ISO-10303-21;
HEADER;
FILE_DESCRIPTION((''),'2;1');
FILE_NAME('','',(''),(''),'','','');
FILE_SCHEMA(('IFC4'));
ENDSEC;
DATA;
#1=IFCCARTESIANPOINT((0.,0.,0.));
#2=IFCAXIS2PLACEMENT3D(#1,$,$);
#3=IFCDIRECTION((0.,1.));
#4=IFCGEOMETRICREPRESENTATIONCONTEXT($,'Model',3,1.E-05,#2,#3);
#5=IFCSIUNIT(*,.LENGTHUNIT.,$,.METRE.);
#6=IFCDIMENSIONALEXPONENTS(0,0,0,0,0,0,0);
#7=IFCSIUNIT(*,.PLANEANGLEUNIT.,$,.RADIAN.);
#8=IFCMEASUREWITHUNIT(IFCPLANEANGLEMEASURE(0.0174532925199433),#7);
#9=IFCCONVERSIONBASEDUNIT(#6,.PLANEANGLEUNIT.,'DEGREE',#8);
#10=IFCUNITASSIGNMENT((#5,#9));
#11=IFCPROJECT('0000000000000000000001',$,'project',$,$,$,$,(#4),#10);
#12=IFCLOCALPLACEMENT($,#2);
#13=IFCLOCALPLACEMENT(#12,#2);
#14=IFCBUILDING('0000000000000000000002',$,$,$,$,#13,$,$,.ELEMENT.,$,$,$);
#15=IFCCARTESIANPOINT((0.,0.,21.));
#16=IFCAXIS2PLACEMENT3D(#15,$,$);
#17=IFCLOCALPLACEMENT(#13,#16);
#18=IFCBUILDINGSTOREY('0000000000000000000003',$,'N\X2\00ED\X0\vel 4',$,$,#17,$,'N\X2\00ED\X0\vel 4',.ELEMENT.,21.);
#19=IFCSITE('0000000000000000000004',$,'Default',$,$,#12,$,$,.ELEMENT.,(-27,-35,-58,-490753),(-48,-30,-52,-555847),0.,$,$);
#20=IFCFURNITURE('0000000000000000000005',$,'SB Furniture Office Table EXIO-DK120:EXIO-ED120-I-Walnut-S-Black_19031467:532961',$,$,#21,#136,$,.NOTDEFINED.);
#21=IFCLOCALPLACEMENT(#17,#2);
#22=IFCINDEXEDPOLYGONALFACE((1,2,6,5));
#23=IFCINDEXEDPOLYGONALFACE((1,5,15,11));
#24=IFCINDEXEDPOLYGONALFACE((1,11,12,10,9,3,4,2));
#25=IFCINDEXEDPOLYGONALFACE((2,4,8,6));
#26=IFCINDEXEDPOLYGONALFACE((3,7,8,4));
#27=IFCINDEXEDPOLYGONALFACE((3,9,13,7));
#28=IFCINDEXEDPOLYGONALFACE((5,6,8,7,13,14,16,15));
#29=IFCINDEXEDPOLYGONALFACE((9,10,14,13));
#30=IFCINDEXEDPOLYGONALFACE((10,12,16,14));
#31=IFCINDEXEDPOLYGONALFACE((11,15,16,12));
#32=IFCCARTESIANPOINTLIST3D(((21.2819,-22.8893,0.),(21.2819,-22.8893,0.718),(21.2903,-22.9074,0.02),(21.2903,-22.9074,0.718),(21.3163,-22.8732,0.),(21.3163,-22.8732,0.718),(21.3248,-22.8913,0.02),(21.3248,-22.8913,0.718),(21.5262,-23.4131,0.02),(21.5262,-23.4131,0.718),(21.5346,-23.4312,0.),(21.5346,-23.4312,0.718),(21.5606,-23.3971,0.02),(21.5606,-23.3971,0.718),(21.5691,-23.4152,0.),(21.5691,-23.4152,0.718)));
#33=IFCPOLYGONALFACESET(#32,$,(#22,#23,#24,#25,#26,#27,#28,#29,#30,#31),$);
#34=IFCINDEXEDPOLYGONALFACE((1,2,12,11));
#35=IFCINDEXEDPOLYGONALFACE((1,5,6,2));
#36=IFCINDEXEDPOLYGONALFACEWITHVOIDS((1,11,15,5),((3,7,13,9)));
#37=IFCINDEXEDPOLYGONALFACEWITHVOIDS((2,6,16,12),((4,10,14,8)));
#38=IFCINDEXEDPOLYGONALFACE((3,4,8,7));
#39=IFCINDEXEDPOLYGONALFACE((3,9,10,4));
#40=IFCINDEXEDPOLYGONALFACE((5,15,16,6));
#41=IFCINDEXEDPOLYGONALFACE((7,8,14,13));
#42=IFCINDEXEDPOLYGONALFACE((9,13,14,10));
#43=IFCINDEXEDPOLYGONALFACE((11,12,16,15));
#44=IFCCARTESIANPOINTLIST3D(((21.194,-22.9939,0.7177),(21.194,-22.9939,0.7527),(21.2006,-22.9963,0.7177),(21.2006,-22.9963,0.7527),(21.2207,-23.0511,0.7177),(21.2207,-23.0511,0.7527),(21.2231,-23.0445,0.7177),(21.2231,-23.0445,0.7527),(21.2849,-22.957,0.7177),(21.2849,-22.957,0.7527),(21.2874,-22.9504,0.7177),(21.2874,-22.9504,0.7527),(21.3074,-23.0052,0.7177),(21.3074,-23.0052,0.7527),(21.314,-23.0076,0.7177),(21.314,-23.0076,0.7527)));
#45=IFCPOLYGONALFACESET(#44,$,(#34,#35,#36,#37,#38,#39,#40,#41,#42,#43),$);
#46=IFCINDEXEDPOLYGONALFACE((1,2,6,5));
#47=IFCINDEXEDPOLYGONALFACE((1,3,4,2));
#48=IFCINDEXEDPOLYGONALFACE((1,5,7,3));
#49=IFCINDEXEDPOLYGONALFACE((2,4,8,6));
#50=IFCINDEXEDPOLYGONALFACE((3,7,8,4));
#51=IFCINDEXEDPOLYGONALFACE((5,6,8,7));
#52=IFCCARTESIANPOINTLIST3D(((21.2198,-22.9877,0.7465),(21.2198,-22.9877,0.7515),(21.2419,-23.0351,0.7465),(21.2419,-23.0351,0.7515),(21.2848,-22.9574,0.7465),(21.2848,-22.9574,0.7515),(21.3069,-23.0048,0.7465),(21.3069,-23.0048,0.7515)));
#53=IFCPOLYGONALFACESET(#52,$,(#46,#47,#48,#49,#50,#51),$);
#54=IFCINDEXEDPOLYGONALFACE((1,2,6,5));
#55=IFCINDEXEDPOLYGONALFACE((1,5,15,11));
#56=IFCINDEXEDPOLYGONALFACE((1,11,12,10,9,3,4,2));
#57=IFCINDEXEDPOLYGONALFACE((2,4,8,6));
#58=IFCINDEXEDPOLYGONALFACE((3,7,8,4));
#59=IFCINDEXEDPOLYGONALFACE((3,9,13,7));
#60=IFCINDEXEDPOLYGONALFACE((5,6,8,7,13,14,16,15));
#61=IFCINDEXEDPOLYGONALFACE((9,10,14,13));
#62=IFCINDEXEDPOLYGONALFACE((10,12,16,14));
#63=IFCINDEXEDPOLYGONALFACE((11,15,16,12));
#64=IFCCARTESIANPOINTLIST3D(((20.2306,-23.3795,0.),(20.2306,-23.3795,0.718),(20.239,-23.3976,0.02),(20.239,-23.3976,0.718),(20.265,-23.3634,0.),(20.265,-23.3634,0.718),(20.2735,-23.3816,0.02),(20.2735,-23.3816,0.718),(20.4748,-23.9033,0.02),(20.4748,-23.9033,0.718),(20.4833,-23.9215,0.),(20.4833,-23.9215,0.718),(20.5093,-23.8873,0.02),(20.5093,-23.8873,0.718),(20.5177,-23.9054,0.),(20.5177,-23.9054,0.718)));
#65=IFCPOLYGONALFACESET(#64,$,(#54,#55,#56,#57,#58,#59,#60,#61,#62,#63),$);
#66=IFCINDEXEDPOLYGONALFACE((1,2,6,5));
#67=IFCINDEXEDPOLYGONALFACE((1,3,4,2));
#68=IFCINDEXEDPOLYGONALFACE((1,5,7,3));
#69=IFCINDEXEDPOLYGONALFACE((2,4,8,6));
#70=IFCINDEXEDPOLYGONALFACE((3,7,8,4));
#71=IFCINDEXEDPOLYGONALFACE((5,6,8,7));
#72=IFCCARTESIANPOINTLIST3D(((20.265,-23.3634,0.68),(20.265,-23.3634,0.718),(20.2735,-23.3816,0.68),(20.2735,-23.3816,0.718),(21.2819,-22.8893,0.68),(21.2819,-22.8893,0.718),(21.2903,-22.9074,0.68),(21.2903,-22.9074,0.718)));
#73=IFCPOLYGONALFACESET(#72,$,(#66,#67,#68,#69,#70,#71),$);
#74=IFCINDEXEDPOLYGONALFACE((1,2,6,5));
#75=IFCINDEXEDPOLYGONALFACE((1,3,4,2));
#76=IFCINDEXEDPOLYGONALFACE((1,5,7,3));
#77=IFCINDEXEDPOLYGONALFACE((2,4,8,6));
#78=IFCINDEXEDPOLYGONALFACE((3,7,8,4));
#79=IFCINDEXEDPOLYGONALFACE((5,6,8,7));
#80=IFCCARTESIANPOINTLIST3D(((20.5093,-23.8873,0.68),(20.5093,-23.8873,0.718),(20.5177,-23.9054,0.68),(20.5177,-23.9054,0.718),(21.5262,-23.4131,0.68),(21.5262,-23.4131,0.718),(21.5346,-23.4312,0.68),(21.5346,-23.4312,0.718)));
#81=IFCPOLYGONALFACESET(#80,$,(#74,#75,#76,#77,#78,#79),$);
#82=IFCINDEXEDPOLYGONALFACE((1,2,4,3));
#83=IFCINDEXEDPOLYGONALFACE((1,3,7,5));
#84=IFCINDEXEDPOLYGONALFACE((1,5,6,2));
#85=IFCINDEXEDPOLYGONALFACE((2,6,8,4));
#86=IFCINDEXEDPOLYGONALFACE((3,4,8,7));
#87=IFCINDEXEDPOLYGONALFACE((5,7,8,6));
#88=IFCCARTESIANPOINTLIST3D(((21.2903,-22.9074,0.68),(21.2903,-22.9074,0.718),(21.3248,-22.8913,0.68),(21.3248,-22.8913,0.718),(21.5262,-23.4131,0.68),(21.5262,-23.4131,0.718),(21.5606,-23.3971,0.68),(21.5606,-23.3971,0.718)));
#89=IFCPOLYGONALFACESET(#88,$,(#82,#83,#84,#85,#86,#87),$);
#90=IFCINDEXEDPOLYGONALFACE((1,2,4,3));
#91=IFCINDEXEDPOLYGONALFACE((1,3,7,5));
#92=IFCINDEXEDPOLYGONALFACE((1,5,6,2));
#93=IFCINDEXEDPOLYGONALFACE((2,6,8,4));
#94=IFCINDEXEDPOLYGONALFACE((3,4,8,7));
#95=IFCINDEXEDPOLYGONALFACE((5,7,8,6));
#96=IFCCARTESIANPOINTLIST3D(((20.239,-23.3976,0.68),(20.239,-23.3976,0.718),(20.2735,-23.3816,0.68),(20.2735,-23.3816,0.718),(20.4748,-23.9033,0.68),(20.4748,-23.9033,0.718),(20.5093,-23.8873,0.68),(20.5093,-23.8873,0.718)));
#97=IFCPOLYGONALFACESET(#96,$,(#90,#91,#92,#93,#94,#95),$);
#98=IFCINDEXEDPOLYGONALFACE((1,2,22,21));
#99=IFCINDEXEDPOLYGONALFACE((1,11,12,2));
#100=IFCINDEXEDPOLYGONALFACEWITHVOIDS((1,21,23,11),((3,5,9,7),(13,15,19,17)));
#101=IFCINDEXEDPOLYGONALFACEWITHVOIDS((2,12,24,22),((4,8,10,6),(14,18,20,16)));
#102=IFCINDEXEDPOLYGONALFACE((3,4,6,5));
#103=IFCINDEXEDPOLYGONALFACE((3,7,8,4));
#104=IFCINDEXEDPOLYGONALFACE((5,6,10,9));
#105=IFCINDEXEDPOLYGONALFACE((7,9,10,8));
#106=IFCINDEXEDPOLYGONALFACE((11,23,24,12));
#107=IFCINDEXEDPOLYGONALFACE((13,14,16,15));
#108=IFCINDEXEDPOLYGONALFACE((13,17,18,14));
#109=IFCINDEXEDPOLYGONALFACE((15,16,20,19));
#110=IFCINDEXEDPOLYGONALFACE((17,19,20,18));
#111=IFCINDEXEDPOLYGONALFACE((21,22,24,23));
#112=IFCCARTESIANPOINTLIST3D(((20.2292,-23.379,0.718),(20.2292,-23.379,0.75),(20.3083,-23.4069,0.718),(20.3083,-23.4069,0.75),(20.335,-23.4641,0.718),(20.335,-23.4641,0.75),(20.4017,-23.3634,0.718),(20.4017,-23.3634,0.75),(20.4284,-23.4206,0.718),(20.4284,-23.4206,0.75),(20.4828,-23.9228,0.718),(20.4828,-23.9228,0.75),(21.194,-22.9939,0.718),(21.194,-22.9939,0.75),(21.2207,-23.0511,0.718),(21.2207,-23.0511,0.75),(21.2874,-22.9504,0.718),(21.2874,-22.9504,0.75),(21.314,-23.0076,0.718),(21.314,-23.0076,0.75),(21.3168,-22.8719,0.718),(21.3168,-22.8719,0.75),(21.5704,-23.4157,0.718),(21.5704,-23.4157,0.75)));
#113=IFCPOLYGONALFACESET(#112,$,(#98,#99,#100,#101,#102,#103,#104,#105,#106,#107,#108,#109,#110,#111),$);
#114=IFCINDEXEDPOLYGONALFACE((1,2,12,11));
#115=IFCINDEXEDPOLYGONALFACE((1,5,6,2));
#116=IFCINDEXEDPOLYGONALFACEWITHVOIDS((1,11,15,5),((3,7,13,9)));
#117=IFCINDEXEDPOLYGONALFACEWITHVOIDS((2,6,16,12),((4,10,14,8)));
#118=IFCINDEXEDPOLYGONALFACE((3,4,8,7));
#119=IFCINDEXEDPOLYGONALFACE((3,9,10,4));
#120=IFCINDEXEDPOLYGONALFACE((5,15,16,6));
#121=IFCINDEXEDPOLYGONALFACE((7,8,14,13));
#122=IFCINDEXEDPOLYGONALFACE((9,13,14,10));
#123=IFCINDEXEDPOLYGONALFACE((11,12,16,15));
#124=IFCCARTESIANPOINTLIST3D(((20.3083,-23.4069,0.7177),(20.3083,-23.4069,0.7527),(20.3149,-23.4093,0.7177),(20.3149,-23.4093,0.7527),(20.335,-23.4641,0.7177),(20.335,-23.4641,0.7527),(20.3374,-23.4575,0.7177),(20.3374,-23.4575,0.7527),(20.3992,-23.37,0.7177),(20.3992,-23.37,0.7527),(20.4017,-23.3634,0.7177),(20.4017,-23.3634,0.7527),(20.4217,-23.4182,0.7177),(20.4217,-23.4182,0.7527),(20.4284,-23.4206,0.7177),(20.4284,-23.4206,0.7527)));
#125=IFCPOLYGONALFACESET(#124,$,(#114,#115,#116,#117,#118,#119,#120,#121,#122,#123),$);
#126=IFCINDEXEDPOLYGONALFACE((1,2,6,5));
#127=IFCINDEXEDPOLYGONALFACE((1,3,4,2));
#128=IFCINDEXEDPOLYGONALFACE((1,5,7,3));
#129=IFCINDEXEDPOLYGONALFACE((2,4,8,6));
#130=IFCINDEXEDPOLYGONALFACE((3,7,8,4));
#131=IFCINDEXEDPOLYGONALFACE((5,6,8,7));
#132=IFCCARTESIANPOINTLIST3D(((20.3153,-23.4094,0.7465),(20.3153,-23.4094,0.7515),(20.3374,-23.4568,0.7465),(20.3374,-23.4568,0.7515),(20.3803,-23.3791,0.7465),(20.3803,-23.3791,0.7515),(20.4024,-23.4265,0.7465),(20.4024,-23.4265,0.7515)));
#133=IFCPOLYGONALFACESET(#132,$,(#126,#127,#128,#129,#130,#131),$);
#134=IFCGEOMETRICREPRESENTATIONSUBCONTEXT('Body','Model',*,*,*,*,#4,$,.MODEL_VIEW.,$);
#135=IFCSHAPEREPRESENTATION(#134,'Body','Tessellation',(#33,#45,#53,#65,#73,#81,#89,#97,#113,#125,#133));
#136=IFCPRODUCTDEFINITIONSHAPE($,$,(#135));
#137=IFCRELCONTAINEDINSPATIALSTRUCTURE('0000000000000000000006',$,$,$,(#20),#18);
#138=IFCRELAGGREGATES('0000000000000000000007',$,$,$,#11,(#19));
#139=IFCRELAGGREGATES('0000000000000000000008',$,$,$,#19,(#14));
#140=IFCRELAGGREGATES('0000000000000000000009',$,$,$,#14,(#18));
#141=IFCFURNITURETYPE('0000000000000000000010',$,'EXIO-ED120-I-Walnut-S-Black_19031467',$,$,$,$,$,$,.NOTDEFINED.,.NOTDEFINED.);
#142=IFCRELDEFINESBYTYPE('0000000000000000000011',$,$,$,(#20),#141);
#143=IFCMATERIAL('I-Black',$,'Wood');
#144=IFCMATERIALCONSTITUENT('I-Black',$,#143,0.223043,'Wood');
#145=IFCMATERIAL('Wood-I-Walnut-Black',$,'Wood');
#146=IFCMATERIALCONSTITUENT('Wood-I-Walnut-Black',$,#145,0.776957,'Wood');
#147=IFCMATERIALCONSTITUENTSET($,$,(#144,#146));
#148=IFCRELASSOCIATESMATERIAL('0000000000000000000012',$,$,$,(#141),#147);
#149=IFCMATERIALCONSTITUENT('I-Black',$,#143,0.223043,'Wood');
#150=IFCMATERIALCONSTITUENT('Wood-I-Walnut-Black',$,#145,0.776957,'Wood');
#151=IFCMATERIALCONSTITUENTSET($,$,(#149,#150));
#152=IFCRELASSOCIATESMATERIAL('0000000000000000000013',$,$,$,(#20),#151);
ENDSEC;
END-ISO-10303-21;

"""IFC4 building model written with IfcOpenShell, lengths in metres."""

from ifc_helpers import new_model, entity, si_unit, converted_unit, direction, frame, frame_2d, origin, origin_2d_with_axis, place, context, subcontext, project, spatial, polyline, rectangle, outline, extrude, source, transform, mapped, material, constituent, constituent_set, type_object, type_shapes, element, save


model = new_model("IFC4")

# Units and contexts
model_context = context("Model", 3, precision=1e-05, world=origin(), true_north=direction((0.0, 1.0)))
body_context = subcontext(model_context, "Body", "Model", "MODEL_VIEW")
ifc_project = project(units=[si_unit("LENGTHUNIT", "METRE"), converted_unit("PLANEANGLEUNIT", "DEGREE", entity("IfcPlaneAngleMeasure", 0.0174532925199433), si_unit("PLANEANGLEUNIT", "RADIAN"), dimensions=[0, 0, 0, 0, 0, 0, 0])], contexts=[model_context])

# Site, building, storey
site_placement = place(None, origin())
site = spatial("IfcSite", under=ifc_project, at=site_placement, Name="Default", CompositionType="ELEMENT", RefLatitude=(-27, -35, -58, -490753), RefLongitude=(-48, -30, -52, -555847), RefElevation=0.0)
building_placement = place(site_placement, origin())
building = spatial("IfcBuilding", under=site, at=building_placement, CompositionType="ELEMENT")
storey_placement = place(building_placement, frame((0.0, 0.0, 21.0)))
storey = spatial("IfcBuildingStorey", under=building, at=storey_placement, Name="Nível 4", LongName="Nível 4", CompositionType="ELEMENT", Elevation=21.0)

# Furniture
ifc_material_1 = material(Name="I-Black", Category="Wood")
ifc_material_2 = material(Name="Wood-I-Walnut-Black", Category="Wood")
ifc_constituent_1 = constituent(ifc_material_1, Name="I-Black", Category="Wood", fraction=0.223043)
ifc_constituent_2 = constituent(ifc_material_2, Name="Wood-I-Walnut-Black", Category="Wood", fraction=0.776957)
ifc_constituent_set_1 = constituent_set(constituents=[ifc_constituent_1, ifc_constituent_2])
furniture_type = type_object("IfcFurnitureType", Name="EXIO-ED120-I-Walnut-S-Black_19031467", AssemblyPlace="NOTDEFINED", PredefinedType="NOTDEFINED", material=ifc_constituent_set_1)
shared_shape_1 = source(origin(), body_context, "Body", "SweptSolid", [
    extrude(outline(polyline([(-0.354, -0.279), (-0.354, -0.299), (0.364, -0.299), (0.364, 0.299), (-0.354, 0.299), (-0.354, 0.279), (0.344, 0.279), (0.344, -0.279), (-0.354, -0.279)])), frame((0.561, 0.0, 0.364), z_axis=(-1.0, 0.0, 0.0), x_axis=(0.0, 0.0, -1.0)), (0.0, 0.0, -1.0), 0.038),
    extrude(outline(polyline([(-0.0316, -0.0515), (0.0316, -0.0515), (0.0316, 0.0515), (-0.0316, 0.0515), (-0.0316, -0.0515)]), holes=[polyline([(0.0266, -0.0465), (-0.0266, -0.0465), (-0.0266, 0.0465), (0.0266, 0.0465), (0.0266, -0.0465)])]), frame((0.4886, 0.2097, 0.7177), z_axis=(0.0, 0.0, 1.0), x_axis=(0.0, -1.0, 0.0)), (0.0, 0.0, 1.0), 0.035),
    extrude(rectangle(XDim=0.0717, YDim=0.0523, at=origin_2d_with_axis()), frame((0.499, 0.2099, 0.7465), z_axis=(0.0, 0.0, 1.0), x_axis=(-1.0, 0.0, 0.0)), (0.0, 0.0, 1.0), 0.005),
    extrude(outline(polyline([(-0.354, -0.279), (-0.354, -0.299), (0.364, -0.299), (0.364, 0.299), (-0.354, 0.299), (-0.354, 0.279), (0.344, 0.279), (0.344, -0.279), (-0.354, -0.279)])), frame((-0.599, 0.0, 0.364), z_axis=(-1.0, 0.0, 0.0), x_axis=(0.0, 0.0, -1.0)), (0.0, 0.0, -1.0), 0.038),
    extrude(rectangle(XDim=1.122, YDim=0.02, at=frame_2d((0.0, 0.0), x_axis=(1.0, 0.0))), frame((0.0, 0.289, 0.68), z_axis=(0.0, 0.0, 1.0), x_axis=(-1.0, 0.0, 0.0)), (0.0, 0.0, 1.0), 0.038),
    extrude(rectangle(XDim=1.122, YDim=0.02, at=origin_2d_with_axis()), frame((0.0, -0.289, 0.68), z_axis=(0.0, 0.0, 1.0), x_axis=(-1.0, 0.0, 0.0)), (0.0, 0.0, 1.0), 0.038),
    extrude(rectangle(XDim=0.038, YDim=0.558, at=frame_2d((0.0, 0.0), x_axis=(1.0, 0.0))), frame((0.58, 0.0, 0.68), z_axis=(0.0, 0.0, 1.0), x_axis=(-1.0, 0.0, 0.0)), (0.0, 0.0, 1.0), 0.038),
    extrude(rectangle(XDim=0.038, YDim=0.558, at=origin_2d_with_axis()), frame((-0.58, 0.0, 0.68), z_axis=(0.0, 0.0, 1.0), x_axis=(-1.0, 0.0, 0.0)), (0.0, 0.0, 1.0), 0.038),
    extrude(outline(polyline([(-0.6, -0.3), (0.6, -0.3), (0.6, 0.3), (-0.6, 0.3), (-0.6, -0.3)]), holes=[polyline([(0.4371, -0.2413), (0.4371, -0.1782), (0.5401, -0.1782), (0.5401, -0.2413), (0.4371, -0.2413)]), polyline([(-0.5401, -0.2413), (-0.5401, -0.1782), (-0.4371, -0.1782), (-0.4371, -0.2413), (-0.5401, -0.2413)])]), frame((0.0, 0.0, 0.718), z_axis=(0.0, 0.0, 1.0), x_axis=(-1.0, 0.0, 0.0)), (0.0, 0.0, 1.0), 0.032),
    extrude(outline(polyline([(-0.0316, -0.0515), (0.0316, -0.0515), (0.0316, 0.0515), (-0.0316, 0.0515), (-0.0316, -0.0515)]), holes=[polyline([(0.0266, -0.0465), (-0.0266, -0.0465), (-0.0266, 0.0465), (0.0266, 0.0465), (0.0266, -0.0465)])]), frame((-0.4886, 0.2097, 0.7177), z_axis=(0.0, 0.0, 1.0), x_axis=(0.0, 1.0, 0.0)), (0.0, 0.0, 1.0), 0.035),
    extrude(rectangle(XDim=0.0523, YDim=0.0717, at=origin_2d_with_axis()), frame((-0.499, 0.2099, 0.7465), z_axis=(0.0, 0.0, 1.0), x_axis=(0.0, -1.0, 0.0)), (0.0, 0.0, 1.0), 0.005),
])
type_shapes(furniture_type, [shared_shape_1])
ifc_constituent_3 = constituent(ifc_material_1, Name="I-Black", Category="Wood", fraction=0.223043)
ifc_constituent_4 = constituent(ifc_material_2, Name="Wood-I-Walnut-Black", Category="Wood", fraction=0.776957)
ifc_constituent_set_2 = constituent_set(constituents=[ifc_constituent_3, ifc_constituent_4])
furniture_1_placement = place(storey_placement, frame((20.8998, -23.3973, 0.0), z_axis=(0.0, 0.0, 1.0), x_axis=(0.906308, 0.422618, 0.0)))
element("IfcFurniture", 1, at=furniture_1_placement, inside=storey, type_object=furniture_type, material=ifc_constituent_set_2, Name="SB Furniture Office Table EXIO-DK120:EXIO-ED120-I-Walnut-S-Black_19031467:532961", PredefinedType="NOTDEFINED", context=body_context, shape_type="MappedRepresentation", body=[
    mapped(shared_shape_1, transform((0.0, 0.0, 0.0), scale=1.0)),
])

save(model, "model.ifc")
